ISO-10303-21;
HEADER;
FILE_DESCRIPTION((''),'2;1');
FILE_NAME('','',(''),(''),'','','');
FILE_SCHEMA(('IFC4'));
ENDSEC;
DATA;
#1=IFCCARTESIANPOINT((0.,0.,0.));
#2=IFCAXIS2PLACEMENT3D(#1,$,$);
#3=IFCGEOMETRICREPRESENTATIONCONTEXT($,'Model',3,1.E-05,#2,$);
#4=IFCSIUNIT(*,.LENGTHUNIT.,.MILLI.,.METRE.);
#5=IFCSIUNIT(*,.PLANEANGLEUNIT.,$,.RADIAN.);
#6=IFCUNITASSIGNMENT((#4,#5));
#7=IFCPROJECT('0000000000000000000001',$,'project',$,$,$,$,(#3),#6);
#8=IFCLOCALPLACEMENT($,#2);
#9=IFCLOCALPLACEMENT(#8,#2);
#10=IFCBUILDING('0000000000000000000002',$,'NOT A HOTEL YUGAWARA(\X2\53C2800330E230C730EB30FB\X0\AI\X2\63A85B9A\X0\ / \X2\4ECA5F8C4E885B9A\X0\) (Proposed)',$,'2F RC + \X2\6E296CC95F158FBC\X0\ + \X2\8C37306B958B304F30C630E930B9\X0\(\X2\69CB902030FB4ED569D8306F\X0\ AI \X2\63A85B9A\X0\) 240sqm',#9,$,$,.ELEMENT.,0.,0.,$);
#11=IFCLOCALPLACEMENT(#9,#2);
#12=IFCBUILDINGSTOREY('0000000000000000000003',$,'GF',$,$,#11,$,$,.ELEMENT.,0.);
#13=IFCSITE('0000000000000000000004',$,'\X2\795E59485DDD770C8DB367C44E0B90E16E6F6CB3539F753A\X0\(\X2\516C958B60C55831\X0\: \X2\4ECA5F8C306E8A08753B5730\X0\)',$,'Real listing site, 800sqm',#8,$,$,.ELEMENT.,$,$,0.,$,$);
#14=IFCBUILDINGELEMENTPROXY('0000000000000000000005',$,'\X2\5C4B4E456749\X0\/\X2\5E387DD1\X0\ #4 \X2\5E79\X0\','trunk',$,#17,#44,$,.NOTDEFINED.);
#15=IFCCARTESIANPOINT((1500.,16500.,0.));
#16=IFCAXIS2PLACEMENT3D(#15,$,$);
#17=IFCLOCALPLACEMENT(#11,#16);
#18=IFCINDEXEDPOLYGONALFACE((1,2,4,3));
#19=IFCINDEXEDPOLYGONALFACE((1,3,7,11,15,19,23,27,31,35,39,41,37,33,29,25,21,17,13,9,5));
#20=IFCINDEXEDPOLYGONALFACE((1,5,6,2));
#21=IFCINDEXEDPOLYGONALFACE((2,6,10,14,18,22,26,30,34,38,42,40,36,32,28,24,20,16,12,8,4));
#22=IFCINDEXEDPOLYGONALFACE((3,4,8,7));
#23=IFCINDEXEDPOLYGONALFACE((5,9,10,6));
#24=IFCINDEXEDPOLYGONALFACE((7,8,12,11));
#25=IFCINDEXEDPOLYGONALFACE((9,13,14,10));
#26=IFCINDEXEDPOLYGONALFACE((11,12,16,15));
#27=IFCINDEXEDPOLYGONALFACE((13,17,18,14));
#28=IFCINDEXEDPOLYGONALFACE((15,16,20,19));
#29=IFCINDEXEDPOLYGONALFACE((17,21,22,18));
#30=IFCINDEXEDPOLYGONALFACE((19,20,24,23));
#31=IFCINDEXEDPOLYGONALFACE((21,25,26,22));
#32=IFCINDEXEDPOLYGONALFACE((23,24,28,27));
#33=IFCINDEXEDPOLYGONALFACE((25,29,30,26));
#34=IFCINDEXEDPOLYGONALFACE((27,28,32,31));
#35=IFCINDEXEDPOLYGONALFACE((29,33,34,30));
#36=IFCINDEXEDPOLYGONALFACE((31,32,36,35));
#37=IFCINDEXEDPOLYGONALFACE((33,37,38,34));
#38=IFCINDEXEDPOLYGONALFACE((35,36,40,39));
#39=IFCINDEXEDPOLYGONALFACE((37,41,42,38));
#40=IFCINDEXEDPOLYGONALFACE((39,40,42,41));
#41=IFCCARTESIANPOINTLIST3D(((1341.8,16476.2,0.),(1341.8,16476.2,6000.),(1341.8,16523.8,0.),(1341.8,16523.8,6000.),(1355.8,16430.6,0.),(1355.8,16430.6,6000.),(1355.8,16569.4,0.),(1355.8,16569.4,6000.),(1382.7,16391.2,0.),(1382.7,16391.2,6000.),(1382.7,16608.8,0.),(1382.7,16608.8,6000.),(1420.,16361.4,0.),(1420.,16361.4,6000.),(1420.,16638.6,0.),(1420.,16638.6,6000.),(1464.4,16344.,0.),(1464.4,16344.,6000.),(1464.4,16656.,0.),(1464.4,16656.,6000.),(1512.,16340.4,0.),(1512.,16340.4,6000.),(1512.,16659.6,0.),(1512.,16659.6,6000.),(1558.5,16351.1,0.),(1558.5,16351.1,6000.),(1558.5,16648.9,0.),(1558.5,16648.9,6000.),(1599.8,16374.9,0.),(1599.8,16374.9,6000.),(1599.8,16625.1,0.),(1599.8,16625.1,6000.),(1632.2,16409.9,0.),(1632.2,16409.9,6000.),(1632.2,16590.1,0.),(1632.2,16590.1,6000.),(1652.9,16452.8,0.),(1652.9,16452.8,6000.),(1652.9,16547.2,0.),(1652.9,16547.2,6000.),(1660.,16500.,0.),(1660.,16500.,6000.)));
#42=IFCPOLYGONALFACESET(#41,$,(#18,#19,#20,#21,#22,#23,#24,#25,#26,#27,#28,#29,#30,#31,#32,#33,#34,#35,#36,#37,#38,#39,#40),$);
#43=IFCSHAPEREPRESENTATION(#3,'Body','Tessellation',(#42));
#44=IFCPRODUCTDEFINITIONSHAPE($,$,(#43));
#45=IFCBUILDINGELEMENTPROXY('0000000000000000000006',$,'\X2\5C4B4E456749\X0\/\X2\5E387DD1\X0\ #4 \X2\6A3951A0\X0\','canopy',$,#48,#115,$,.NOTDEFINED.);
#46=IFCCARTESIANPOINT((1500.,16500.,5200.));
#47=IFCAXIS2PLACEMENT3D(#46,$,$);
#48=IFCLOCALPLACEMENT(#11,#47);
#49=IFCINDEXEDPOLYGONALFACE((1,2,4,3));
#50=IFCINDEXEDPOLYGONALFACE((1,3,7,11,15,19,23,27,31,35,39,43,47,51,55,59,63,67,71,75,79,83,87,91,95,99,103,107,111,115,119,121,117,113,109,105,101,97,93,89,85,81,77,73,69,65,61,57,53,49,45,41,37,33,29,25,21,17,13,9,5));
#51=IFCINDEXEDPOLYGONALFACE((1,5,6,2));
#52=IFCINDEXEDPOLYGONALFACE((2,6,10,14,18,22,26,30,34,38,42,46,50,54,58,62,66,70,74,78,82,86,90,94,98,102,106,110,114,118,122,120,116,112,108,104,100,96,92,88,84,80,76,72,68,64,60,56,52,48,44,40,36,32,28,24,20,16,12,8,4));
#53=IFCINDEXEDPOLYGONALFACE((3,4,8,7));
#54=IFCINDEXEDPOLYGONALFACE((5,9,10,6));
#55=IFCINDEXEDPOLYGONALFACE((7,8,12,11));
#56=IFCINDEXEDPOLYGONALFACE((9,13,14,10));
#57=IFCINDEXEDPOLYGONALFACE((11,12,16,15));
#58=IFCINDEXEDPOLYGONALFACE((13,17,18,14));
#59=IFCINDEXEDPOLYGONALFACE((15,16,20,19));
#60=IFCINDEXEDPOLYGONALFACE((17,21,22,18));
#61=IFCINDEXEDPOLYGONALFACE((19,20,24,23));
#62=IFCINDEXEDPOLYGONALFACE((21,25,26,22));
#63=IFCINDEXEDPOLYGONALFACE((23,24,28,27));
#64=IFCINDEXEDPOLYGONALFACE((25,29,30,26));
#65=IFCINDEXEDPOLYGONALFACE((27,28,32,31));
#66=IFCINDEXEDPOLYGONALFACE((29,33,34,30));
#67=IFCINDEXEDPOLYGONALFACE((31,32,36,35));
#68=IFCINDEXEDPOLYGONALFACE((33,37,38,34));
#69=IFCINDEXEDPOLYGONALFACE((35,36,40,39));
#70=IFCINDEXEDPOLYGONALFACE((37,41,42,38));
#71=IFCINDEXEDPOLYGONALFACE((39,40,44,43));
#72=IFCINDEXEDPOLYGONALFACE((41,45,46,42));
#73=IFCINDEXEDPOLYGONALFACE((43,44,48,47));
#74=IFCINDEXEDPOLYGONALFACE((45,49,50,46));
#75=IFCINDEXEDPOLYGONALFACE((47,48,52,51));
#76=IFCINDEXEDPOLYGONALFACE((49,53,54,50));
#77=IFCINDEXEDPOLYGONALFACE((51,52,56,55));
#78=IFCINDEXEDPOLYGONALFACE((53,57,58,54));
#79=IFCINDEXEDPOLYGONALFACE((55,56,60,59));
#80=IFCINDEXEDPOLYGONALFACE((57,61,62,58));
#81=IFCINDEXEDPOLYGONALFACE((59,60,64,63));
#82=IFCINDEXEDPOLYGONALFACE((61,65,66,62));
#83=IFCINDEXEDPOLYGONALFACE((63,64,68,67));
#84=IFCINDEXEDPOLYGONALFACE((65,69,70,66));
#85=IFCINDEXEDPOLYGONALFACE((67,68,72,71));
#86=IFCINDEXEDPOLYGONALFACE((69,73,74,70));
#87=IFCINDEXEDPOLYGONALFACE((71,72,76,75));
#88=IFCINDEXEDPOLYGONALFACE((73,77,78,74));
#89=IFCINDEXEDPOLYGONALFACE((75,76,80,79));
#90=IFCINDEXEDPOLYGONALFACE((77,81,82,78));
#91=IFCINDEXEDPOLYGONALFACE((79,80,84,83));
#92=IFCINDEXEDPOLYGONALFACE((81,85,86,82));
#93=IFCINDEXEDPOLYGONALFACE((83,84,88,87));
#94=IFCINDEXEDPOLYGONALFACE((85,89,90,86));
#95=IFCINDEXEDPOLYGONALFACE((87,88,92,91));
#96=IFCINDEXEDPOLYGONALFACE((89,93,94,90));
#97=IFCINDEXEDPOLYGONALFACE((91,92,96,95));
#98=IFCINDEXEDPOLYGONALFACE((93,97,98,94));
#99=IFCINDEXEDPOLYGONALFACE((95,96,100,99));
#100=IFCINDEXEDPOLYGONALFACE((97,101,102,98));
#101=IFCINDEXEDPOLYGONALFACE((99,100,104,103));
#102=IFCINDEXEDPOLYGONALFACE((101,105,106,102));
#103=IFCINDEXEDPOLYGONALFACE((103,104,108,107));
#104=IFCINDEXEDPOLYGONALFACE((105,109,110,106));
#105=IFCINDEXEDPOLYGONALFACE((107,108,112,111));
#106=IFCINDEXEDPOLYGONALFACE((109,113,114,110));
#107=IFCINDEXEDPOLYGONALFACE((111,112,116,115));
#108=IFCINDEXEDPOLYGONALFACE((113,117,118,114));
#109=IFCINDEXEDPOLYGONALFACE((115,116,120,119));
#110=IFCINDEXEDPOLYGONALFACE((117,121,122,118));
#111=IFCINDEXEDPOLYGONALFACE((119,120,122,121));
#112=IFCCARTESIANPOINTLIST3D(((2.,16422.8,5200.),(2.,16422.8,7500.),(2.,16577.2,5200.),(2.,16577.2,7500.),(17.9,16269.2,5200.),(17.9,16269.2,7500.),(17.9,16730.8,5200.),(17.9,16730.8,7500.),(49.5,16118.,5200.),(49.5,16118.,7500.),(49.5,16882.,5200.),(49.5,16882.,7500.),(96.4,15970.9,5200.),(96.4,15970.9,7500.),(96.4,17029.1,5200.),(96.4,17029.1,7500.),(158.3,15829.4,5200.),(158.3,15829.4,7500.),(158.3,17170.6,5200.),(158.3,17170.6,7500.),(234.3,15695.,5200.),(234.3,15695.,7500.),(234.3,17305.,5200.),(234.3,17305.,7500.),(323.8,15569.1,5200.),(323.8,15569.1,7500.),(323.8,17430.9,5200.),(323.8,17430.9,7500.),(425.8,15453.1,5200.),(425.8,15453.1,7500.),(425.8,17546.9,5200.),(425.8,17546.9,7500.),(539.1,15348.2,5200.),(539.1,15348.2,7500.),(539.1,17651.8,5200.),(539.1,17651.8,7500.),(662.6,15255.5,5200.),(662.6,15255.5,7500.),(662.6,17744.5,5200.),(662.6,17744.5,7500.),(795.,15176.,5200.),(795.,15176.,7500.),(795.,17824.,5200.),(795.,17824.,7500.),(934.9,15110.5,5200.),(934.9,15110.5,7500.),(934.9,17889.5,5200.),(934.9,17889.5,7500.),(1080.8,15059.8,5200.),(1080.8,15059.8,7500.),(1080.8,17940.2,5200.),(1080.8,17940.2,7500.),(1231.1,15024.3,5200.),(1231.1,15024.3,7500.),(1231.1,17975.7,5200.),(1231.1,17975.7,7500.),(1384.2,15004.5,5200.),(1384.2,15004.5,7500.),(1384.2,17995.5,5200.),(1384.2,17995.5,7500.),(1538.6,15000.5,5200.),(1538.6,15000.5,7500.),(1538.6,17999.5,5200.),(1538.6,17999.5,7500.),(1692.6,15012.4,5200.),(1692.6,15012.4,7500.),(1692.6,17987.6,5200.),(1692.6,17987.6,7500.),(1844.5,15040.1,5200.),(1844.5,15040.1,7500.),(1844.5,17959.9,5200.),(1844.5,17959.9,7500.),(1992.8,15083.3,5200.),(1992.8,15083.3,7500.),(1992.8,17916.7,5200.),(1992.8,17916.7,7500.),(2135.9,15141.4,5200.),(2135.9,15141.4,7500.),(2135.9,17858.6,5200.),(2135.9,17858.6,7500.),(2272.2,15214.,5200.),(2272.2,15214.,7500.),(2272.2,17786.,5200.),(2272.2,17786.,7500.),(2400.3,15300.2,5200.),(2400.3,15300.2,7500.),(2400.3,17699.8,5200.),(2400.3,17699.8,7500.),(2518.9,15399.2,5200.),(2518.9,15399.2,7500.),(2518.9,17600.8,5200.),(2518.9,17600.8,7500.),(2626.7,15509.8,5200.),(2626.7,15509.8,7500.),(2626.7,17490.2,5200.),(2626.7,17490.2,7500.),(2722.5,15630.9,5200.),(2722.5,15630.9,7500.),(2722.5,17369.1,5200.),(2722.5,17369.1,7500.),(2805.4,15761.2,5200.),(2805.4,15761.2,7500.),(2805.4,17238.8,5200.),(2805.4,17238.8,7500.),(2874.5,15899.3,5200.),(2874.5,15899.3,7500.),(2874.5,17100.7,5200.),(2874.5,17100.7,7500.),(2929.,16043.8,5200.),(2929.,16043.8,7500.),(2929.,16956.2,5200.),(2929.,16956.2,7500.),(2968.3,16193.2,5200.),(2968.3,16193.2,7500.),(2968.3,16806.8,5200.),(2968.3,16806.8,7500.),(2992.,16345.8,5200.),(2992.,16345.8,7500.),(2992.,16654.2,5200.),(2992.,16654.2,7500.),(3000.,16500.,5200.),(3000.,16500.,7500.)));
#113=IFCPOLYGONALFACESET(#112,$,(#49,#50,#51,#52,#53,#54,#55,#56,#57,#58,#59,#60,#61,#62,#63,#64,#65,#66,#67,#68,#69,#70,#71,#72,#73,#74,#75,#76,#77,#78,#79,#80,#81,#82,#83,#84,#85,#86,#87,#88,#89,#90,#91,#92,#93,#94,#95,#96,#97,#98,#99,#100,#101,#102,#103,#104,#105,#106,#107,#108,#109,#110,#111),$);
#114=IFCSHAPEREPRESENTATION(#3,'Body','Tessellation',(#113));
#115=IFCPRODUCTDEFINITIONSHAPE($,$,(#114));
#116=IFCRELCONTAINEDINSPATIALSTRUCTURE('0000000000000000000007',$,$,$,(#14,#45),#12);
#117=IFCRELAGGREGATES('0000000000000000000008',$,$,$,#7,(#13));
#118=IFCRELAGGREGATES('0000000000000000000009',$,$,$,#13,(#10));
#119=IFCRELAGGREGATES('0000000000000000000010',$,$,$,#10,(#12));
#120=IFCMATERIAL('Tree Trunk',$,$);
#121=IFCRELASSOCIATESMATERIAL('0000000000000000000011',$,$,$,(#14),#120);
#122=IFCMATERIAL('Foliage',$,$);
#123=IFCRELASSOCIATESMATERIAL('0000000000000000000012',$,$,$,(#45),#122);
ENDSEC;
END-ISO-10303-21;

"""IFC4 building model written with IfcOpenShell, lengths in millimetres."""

from ifc_helpers import new_model, si_unit, frame, origin, origin_2d, place, context, project, spatial, circle, extrude, material, element, save


model = new_model("IFC4")

# Units and contexts
model_context = context("Model", 3, precision=1e-05, world=origin())
ifc_project = project(units=[si_unit("LENGTHUNIT", "METRE", prefix="MILLI"), si_unit("PLANEANGLEUNIT", "RADIAN")], contexts=[model_context])

# Site, building, storey
site_placement = place(None, origin())
site = spatial("IfcSite", under=ifc_project, at=site_placement, Name="神奈川県足柄下郡湯河原町(公開情報: 今後の計画地)", ObjectType="Real listing site, 800sqm", CompositionType="ELEMENT", RefElevation=0.0)
building_placement = place(site_placement, origin())
building = spatial("IfcBuilding", under=site, at=building_placement, Name="NOT A HOTEL YUGAWARA(参考モデル・AI推定 / 今後予定) (Proposed)", ObjectType="2F RC + 温泉引込 + 谷に開くテラス(構造・仕様は AI 推定) 240sqm", CompositionType="ELEMENT", ElevationOfRefHeight=0.0, ElevationOfTerrain=0.0)
storey_placement = place(building_placement, origin())
storey = spatial("IfcBuildingStorey", under=building, at=storey_placement, Name="GF", CompositionType="ELEMENT", Elevation=0.0)

# Building element proxies
ifc_material_1 = material(Name="Tree Trunk")
ifc_material_2 = material(Name="Foliage")
proxy_1_placement = place(storey_placement, frame((1500.0, 16500.0, 0.0)))
element("IfcBuildingElementProxy", 1, at=proxy_1_placement, inside=storey, material=ifc_material_1, Name="屋久杉/常緑 #4 幹", Description="trunk", PredefinedType="NOTDEFINED", context=model_context, shape_type="SweptSolid", body=[
    extrude(circle(Radius=160.0, at=origin_2d()), frame((1500.0, 16500.0, 0.0)), (0.0, 0.0, 1.0), 6000.0),
])
proxy_2_placement = place(storey_placement, frame((1500.0, 16500.0, 5200.0)))
element("IfcBuildingElementProxy", 2, at=proxy_2_placement, inside=storey, material=ifc_material_2, Name="屋久杉/常緑 #4 樹冠", Description="canopy", PredefinedType="NOTDEFINED", context=model_context, shape_type="SweptSolid", body=[
    extrude(circle(Radius=1500.0, at=origin_2d()), frame((1500.0, 16500.0, 5200.0)), (0.0, 0.0, 1.0), 2300.0),
])

save(model, "model.ifc")
